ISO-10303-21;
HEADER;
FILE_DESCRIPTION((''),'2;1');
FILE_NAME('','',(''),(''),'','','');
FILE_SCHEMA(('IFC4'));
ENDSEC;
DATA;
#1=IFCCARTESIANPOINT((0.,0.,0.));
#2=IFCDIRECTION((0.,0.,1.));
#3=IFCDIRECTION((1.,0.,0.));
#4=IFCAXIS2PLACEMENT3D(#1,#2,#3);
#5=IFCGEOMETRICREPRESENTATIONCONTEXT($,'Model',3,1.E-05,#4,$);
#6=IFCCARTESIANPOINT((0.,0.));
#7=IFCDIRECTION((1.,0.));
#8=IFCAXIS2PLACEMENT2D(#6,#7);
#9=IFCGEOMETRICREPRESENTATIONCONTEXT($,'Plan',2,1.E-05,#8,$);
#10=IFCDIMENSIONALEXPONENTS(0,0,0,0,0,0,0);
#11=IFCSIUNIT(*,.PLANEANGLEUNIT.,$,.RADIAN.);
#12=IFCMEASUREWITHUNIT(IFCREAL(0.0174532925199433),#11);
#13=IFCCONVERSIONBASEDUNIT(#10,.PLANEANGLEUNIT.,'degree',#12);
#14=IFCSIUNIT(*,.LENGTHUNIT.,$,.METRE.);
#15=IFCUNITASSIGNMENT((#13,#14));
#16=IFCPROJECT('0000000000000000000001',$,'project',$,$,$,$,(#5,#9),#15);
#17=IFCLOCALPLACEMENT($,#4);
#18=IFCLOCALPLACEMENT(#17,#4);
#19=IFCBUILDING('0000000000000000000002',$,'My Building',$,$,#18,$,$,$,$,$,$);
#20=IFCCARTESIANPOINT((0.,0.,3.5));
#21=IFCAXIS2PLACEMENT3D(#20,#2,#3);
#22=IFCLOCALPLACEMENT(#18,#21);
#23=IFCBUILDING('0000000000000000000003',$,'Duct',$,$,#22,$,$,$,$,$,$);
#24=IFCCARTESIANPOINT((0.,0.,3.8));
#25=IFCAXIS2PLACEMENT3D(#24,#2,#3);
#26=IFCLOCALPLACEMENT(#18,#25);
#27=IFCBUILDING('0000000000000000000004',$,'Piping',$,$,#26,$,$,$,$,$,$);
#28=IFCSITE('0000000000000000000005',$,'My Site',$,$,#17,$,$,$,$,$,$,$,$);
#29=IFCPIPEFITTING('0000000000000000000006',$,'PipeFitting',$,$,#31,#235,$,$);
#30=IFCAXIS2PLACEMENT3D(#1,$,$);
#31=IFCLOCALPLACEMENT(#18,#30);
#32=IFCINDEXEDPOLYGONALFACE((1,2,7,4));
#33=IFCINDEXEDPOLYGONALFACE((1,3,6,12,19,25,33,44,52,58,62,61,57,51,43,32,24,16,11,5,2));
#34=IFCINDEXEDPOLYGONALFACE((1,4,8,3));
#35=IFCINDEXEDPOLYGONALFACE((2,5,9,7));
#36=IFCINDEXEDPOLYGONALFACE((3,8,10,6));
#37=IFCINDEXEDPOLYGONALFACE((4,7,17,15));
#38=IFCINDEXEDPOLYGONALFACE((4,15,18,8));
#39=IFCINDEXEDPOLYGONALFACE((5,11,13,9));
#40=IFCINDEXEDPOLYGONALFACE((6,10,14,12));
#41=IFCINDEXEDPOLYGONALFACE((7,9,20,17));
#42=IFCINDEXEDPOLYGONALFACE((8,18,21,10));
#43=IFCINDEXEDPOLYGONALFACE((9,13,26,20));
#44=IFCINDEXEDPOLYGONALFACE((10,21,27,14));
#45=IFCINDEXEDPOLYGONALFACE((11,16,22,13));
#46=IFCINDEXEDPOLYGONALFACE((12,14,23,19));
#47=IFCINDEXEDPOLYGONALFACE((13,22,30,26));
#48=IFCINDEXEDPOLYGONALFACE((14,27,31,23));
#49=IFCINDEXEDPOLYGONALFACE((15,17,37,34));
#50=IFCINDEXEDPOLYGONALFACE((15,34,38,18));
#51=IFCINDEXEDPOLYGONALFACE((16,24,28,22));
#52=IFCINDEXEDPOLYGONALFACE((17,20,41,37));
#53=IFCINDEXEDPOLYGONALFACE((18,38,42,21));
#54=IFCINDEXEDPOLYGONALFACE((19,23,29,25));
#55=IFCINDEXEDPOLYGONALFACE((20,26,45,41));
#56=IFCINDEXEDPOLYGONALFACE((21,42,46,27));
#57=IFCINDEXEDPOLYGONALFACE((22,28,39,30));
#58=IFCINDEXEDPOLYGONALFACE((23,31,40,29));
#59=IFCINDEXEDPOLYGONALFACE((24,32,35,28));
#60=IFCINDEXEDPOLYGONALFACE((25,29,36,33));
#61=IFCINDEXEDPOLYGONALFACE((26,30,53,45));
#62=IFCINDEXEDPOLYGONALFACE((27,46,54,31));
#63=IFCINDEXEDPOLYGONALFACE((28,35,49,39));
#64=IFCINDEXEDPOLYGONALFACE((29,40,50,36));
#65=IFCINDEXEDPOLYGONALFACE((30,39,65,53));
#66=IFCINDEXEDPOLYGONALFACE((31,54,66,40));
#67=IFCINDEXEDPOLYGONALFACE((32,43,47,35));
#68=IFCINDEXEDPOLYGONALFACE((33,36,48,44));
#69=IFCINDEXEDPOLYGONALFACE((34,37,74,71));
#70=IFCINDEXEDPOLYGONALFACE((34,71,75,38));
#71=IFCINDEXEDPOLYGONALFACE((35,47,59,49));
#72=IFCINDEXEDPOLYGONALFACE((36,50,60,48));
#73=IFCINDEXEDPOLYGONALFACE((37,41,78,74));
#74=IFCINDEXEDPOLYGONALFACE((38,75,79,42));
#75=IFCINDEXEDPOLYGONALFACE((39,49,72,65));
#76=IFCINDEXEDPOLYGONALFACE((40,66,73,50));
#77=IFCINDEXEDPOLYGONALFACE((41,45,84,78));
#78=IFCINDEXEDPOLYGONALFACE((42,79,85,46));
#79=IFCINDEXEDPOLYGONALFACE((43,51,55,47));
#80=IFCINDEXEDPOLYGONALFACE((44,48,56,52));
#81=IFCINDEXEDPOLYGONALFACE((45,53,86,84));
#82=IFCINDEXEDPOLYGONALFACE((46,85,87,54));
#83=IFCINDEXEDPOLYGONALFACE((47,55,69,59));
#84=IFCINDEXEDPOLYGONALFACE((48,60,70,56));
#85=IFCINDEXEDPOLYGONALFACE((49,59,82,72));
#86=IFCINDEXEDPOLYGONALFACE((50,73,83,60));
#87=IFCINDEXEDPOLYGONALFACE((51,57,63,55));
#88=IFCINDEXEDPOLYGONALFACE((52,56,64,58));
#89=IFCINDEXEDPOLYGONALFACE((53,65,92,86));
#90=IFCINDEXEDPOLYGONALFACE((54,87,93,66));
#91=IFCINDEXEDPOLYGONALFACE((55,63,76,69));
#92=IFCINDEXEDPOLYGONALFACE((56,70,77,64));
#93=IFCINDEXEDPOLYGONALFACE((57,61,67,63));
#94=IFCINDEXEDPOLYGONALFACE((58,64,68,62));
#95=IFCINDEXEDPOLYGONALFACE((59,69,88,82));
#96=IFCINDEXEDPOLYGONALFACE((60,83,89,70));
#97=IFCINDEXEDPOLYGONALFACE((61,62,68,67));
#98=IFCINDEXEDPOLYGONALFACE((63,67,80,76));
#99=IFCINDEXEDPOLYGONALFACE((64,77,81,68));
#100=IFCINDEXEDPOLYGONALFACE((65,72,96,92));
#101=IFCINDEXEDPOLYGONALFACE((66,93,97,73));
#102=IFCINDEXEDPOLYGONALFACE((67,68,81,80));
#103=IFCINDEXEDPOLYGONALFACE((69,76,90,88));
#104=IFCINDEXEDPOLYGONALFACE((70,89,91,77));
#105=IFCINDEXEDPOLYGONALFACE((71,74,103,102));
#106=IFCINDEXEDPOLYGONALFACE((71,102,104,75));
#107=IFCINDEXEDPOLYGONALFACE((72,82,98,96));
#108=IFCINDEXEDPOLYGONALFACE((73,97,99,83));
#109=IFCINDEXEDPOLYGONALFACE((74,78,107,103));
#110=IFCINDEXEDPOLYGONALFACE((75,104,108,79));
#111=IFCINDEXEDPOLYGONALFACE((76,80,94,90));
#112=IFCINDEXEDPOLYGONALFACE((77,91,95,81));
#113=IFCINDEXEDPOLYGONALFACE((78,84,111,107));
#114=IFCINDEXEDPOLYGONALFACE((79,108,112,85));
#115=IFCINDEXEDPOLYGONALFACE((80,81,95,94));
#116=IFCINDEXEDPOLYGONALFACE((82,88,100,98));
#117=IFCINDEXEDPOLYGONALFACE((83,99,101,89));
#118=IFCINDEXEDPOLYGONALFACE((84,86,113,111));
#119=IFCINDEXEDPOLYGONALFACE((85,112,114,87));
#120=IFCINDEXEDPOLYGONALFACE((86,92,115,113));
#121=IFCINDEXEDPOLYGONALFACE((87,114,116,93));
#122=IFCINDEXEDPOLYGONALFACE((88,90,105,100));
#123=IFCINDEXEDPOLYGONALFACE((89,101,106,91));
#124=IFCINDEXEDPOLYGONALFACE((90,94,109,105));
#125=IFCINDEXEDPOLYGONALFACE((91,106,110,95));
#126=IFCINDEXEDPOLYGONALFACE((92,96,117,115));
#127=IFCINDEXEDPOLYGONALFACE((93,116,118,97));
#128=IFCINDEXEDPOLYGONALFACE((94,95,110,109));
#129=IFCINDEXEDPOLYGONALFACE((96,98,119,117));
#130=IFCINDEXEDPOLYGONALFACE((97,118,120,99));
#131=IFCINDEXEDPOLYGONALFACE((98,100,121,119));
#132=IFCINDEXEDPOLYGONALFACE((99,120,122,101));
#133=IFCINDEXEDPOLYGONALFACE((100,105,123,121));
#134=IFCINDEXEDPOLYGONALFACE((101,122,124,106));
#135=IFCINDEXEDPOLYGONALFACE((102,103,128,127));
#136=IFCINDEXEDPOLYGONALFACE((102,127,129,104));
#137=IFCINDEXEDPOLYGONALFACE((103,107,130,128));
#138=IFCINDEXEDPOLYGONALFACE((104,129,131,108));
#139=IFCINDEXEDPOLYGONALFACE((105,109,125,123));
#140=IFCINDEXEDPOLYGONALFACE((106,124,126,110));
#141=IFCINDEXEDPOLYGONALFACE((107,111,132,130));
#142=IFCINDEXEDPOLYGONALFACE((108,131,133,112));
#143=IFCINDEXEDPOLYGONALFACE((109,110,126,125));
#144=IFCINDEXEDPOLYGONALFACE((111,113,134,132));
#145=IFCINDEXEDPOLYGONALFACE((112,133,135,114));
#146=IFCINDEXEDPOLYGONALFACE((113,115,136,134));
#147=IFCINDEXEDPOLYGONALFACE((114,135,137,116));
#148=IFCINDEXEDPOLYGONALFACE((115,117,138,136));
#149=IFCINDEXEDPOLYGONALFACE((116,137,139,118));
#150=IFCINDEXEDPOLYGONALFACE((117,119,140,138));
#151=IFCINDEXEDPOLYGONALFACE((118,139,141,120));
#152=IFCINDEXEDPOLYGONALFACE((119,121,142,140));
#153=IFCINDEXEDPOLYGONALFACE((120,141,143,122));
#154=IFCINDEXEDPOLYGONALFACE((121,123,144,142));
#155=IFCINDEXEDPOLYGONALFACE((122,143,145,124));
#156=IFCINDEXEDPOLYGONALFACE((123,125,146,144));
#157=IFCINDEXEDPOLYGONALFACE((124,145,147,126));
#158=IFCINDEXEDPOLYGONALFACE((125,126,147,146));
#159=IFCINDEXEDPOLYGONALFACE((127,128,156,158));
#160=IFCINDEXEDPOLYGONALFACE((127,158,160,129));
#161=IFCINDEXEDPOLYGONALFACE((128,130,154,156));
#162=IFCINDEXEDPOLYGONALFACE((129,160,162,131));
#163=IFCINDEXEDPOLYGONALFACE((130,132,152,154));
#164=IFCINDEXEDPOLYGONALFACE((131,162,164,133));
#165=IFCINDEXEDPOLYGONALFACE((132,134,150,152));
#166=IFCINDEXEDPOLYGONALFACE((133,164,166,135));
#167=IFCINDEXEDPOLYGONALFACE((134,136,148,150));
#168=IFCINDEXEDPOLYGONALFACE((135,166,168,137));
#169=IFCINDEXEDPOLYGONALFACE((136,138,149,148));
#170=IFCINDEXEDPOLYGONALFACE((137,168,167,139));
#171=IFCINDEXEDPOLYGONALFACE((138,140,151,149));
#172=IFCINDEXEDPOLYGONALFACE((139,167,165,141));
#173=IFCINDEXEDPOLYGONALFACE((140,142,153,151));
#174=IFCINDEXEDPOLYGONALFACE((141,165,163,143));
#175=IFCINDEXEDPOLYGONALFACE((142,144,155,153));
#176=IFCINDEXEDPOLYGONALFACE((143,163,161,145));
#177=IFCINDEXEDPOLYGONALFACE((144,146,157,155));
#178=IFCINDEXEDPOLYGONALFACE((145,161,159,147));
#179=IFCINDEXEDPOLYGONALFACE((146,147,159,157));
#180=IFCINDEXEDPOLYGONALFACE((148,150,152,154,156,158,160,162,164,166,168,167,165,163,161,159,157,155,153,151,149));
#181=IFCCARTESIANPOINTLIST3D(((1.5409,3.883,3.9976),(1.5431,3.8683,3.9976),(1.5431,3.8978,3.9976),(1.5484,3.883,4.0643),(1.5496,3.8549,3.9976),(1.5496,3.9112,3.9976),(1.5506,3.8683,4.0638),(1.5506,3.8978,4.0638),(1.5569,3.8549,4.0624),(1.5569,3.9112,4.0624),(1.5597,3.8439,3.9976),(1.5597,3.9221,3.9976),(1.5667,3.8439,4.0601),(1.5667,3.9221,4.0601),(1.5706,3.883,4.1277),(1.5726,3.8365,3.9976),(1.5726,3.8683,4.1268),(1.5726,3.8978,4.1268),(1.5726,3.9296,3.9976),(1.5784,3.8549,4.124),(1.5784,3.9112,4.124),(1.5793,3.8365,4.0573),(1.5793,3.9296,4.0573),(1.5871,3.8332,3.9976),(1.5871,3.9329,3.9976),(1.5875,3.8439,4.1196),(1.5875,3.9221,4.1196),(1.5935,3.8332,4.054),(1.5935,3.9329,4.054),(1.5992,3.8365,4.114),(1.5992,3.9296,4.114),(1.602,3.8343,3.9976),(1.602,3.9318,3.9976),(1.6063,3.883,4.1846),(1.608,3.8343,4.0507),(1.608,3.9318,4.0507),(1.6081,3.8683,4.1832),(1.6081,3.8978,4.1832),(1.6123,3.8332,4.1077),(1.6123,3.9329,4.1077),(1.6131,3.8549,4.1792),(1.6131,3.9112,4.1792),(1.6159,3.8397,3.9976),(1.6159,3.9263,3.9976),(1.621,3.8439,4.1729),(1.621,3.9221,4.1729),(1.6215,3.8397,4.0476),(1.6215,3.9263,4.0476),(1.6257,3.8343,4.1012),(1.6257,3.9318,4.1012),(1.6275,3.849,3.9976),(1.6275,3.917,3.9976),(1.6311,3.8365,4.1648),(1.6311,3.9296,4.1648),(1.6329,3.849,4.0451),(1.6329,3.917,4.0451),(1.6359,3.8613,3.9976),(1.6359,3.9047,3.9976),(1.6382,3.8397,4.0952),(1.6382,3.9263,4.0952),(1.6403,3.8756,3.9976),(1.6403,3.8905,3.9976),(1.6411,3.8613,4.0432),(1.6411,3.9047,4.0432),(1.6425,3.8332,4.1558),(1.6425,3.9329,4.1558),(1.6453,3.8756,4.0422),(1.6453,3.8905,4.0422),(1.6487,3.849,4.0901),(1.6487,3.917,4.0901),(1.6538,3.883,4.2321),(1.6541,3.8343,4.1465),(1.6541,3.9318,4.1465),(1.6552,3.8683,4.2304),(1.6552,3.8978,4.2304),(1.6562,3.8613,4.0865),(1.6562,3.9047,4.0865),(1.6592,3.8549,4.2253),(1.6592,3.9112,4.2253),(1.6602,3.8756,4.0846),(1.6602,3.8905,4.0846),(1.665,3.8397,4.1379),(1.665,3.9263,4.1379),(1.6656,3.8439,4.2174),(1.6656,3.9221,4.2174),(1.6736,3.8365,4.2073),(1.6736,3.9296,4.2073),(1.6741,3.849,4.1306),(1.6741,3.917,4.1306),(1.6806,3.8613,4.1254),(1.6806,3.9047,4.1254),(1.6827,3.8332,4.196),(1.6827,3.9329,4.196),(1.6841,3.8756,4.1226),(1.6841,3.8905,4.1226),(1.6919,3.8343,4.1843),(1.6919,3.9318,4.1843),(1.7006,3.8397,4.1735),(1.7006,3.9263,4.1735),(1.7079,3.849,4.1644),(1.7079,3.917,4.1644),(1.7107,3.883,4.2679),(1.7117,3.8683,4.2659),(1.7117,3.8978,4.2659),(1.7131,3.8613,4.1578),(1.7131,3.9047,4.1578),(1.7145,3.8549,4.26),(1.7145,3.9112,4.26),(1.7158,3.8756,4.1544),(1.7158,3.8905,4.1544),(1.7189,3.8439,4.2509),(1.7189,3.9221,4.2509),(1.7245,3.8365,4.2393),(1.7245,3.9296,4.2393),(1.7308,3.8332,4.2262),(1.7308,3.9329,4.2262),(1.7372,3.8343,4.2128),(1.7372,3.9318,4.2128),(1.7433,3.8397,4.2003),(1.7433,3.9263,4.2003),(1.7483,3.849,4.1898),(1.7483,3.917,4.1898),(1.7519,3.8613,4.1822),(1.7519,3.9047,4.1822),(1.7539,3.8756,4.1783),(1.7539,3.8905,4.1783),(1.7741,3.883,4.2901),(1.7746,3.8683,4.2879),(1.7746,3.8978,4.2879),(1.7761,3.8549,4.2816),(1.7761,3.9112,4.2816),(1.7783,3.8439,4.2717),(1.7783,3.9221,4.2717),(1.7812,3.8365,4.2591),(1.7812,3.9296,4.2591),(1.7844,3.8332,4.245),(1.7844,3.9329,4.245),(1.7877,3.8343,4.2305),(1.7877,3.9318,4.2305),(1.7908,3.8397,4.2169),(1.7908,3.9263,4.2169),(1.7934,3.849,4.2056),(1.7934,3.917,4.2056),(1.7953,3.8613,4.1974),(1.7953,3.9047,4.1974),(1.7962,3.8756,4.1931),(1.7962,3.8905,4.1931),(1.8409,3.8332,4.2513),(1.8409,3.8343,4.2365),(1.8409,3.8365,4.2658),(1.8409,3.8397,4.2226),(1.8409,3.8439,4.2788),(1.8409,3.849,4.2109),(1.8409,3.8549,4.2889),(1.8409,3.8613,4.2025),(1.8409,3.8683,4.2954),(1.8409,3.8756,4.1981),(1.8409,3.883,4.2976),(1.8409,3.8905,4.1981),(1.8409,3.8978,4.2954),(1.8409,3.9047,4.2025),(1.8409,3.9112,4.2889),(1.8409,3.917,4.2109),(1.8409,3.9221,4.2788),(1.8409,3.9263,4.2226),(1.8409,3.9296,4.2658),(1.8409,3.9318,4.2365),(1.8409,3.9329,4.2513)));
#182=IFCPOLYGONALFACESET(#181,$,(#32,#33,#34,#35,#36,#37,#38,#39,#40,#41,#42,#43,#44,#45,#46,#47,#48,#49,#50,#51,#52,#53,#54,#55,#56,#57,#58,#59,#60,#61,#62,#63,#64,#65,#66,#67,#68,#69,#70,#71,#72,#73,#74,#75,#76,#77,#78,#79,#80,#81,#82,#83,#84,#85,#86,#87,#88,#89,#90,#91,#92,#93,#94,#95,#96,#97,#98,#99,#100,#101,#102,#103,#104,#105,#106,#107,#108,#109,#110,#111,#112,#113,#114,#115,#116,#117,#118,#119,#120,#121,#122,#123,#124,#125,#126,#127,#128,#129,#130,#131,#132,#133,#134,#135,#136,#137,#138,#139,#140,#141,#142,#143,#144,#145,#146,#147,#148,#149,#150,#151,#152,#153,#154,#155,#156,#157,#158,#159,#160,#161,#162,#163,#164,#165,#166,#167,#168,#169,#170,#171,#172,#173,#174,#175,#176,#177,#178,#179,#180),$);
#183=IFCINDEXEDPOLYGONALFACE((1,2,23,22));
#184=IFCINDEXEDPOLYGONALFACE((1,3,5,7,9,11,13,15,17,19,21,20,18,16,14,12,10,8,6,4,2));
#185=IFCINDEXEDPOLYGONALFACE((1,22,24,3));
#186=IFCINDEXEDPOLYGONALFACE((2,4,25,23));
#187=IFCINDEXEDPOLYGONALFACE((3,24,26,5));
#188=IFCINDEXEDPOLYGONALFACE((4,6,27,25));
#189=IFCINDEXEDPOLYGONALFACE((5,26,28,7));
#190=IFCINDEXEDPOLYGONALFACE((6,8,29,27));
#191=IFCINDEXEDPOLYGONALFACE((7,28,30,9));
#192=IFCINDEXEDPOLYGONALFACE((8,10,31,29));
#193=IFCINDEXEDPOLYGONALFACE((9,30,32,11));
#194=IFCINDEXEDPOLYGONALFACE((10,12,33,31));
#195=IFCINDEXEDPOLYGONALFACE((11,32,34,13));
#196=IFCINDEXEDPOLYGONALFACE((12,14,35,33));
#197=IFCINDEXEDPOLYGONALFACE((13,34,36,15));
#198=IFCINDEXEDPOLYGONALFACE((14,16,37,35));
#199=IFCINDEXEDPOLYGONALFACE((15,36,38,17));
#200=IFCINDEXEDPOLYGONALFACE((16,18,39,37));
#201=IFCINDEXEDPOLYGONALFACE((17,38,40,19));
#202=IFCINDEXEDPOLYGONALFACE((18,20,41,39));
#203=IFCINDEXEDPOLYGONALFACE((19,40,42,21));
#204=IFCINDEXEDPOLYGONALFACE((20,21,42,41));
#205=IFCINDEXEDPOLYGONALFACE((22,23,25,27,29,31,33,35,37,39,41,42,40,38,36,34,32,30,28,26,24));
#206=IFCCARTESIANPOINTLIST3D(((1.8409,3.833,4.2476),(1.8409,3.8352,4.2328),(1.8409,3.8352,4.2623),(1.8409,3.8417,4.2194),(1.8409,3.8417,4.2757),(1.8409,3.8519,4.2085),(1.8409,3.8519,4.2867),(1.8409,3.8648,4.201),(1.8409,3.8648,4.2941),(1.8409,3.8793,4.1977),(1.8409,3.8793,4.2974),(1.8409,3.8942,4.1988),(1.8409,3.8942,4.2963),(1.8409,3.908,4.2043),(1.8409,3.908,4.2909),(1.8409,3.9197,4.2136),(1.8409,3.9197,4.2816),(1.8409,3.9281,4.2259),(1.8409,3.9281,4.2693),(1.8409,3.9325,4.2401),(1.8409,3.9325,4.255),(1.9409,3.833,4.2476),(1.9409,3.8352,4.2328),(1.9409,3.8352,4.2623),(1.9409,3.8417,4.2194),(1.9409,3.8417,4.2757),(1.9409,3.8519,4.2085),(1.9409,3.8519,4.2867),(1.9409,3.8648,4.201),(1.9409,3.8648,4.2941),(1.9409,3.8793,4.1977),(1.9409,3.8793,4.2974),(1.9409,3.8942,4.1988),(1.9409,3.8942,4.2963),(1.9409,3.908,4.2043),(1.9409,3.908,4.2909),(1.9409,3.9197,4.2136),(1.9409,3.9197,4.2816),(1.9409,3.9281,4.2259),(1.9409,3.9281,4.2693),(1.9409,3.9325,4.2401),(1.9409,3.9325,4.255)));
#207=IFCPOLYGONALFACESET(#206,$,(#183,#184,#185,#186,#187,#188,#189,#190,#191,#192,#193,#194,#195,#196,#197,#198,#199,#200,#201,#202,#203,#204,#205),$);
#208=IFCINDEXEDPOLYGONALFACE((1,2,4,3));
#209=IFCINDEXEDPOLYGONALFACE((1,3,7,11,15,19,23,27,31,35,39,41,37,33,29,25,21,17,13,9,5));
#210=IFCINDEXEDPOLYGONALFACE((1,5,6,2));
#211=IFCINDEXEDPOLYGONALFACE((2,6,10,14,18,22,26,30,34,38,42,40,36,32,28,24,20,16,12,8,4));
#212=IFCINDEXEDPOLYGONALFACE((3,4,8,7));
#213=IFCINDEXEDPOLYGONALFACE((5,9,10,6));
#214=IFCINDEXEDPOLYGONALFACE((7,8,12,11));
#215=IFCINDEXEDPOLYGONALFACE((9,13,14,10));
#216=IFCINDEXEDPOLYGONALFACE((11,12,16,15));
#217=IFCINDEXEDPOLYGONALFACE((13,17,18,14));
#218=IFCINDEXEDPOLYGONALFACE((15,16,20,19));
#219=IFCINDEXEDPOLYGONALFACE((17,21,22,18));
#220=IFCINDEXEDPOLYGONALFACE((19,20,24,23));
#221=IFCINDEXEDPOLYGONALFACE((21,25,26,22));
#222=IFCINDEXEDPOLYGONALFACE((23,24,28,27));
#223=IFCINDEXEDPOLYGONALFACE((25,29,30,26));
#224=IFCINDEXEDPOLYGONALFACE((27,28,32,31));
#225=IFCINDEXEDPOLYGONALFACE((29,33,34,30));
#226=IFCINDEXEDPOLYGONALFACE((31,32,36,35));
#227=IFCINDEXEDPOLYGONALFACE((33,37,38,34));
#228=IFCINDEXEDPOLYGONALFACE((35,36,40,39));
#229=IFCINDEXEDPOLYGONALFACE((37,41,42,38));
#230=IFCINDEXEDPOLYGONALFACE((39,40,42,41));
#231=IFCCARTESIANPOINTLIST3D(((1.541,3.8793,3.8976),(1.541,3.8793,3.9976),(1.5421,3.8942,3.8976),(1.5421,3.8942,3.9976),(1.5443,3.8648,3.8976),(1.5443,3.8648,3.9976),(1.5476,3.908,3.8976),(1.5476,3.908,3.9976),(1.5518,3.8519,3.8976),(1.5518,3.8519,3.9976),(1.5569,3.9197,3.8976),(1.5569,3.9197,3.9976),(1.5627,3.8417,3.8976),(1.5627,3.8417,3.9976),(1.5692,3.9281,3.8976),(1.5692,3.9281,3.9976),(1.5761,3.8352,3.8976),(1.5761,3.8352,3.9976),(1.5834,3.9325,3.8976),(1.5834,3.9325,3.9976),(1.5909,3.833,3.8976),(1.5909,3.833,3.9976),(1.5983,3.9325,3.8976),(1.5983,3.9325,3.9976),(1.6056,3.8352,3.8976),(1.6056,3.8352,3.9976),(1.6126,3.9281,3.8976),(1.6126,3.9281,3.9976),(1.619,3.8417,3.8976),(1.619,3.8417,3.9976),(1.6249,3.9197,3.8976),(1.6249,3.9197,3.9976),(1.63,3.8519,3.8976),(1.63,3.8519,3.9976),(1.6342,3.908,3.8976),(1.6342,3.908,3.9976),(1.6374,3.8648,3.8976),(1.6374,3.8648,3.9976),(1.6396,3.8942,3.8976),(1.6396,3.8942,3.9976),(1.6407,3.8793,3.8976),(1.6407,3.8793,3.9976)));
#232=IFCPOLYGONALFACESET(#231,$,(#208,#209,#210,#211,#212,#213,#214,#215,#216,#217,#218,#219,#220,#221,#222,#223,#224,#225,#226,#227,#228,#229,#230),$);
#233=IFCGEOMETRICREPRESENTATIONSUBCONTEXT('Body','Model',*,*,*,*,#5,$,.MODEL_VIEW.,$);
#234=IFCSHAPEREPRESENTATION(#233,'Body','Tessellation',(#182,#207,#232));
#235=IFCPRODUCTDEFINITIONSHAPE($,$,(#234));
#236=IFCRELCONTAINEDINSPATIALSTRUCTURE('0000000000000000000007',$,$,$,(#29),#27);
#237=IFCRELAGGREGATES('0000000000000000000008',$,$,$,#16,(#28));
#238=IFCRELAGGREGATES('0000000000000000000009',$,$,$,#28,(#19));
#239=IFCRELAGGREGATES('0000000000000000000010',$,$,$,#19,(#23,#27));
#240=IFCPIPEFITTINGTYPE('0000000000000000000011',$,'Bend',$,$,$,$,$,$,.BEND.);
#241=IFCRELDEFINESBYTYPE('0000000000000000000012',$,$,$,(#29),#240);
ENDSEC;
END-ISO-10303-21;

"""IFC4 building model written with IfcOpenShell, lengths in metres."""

from ifc_helpers import new_model, entity, si_unit, converted_unit, frame, origin_with_axes, origin_2d_with_axis, place, context, subcontext, project, spatial, circle, extrude, source, transform, mapped, type_object, type_shapes, element, save


model = new_model("IFC4")

# Units and contexts
model_context = context("Model", 3, precision=1e-05, world=origin_with_axes())
plan_context = context("Plan", 2, precision=1e-05, world=origin_2d_with_axis())
body_context = subcontext(model_context, "Body", "Model", "MODEL_VIEW")
ifc_project = project(units=[converted_unit("PLANEANGLEUNIT", "degree", entity("IfcReal", 0.0174532925199433), si_unit("PLANEANGLEUNIT", "RADIAN"), dimensions=[0, 0, 0, 0, 0, 0, 0]), si_unit("LENGTHUNIT", "METRE")], contexts=[model_context, plan_context])

# Site, building
site_placement = place(None, origin_with_axes())
site = spatial("IfcSite", under=ifc_project, at=site_placement, Name="My Site")
building_1_placement = place(site_placement, origin_with_axes())
building_1 = spatial("IfcBuilding", under=site, at=building_1_placement, Name="My Building")

# Shared definitions
building_2_placement = place(building_1_placement, frame((0.0, 0.0, 3.5), z_axis=(0.0, 0.0, 1.0), x_axis=(1.0, 0.0, 0.0)))
building_2 = spatial("IfcBuilding", under=building_1, at=building_2_placement, Name="Duct")

# Shared definitions
building_3_placement = place(building_1_placement, frame((0.0, 0.0, 3.8), z_axis=(0.0, 0.0, 1.0), x_axis=(1.0, 0.0, 0.0)))
building_3 = spatial("IfcBuilding", under=building_1, at=building_3_placement, Name="Piping")

# Pipe fitting
pipe_fitting_type_1 = type_object("IfcPipeFittingType", Name="Bend", PredefinedType="BEND")
shared_shape = source(origin_with_axes(), body_context, "Body", "SolidModel", [
    entity("IfcSweptDiskSolid", entity("IfcIndexedPolyCurve", entity("IfcCartesianPointList3D", [[0.0, 0.0, 0.1], [0.0, -0.0732, 0.2768], [0.0, -0.25, 0.35]]), [entity("IfcArcIndex", [1, 2, 3])]), 0.05),
    extrude(circle(Radius=0.05), origin_with_axes(), (0.0, 0.0, 1.0), 0.1),
    extrude(circle(Radius=0.05), frame((0.0, -0.25, 0.35), z_axis=(0.0, -1.0, -0.000001), x_axis=(1.0, 0.0, 0.0)), (0.0, 0.0, 1.0), 0.1),
])
type_shapes(pipe_fitting_type_1, [shared_shape])
for number, where, z_axis, x_axis, name in (
    (1, (1.9409, 3.883, 0.4476), (-1.0, 0.000001, -0.000001), (-0.000001, -1.0, 0.0), "PipeFitting"),
):
    element("IfcPipeFitting", number, at=place(building_3_placement, frame(where, z_axis=z_axis, x_axis=x_axis)), inside=building_3, type_object=pipe_fitting_type_1, Name=name, context=body_context, shape_type="MappedRepresentation", body=[
        mapped(shared_shape, transform((0.0, 0.0, 0.0), x_axis=(1.0, 0.0, 0.0), y_axis=(0.0, 1.0, 0.0), z_axis=(0.0, 0.0, 1.0), scale=1.0)),
    ])

save(model, "model.ifc")
